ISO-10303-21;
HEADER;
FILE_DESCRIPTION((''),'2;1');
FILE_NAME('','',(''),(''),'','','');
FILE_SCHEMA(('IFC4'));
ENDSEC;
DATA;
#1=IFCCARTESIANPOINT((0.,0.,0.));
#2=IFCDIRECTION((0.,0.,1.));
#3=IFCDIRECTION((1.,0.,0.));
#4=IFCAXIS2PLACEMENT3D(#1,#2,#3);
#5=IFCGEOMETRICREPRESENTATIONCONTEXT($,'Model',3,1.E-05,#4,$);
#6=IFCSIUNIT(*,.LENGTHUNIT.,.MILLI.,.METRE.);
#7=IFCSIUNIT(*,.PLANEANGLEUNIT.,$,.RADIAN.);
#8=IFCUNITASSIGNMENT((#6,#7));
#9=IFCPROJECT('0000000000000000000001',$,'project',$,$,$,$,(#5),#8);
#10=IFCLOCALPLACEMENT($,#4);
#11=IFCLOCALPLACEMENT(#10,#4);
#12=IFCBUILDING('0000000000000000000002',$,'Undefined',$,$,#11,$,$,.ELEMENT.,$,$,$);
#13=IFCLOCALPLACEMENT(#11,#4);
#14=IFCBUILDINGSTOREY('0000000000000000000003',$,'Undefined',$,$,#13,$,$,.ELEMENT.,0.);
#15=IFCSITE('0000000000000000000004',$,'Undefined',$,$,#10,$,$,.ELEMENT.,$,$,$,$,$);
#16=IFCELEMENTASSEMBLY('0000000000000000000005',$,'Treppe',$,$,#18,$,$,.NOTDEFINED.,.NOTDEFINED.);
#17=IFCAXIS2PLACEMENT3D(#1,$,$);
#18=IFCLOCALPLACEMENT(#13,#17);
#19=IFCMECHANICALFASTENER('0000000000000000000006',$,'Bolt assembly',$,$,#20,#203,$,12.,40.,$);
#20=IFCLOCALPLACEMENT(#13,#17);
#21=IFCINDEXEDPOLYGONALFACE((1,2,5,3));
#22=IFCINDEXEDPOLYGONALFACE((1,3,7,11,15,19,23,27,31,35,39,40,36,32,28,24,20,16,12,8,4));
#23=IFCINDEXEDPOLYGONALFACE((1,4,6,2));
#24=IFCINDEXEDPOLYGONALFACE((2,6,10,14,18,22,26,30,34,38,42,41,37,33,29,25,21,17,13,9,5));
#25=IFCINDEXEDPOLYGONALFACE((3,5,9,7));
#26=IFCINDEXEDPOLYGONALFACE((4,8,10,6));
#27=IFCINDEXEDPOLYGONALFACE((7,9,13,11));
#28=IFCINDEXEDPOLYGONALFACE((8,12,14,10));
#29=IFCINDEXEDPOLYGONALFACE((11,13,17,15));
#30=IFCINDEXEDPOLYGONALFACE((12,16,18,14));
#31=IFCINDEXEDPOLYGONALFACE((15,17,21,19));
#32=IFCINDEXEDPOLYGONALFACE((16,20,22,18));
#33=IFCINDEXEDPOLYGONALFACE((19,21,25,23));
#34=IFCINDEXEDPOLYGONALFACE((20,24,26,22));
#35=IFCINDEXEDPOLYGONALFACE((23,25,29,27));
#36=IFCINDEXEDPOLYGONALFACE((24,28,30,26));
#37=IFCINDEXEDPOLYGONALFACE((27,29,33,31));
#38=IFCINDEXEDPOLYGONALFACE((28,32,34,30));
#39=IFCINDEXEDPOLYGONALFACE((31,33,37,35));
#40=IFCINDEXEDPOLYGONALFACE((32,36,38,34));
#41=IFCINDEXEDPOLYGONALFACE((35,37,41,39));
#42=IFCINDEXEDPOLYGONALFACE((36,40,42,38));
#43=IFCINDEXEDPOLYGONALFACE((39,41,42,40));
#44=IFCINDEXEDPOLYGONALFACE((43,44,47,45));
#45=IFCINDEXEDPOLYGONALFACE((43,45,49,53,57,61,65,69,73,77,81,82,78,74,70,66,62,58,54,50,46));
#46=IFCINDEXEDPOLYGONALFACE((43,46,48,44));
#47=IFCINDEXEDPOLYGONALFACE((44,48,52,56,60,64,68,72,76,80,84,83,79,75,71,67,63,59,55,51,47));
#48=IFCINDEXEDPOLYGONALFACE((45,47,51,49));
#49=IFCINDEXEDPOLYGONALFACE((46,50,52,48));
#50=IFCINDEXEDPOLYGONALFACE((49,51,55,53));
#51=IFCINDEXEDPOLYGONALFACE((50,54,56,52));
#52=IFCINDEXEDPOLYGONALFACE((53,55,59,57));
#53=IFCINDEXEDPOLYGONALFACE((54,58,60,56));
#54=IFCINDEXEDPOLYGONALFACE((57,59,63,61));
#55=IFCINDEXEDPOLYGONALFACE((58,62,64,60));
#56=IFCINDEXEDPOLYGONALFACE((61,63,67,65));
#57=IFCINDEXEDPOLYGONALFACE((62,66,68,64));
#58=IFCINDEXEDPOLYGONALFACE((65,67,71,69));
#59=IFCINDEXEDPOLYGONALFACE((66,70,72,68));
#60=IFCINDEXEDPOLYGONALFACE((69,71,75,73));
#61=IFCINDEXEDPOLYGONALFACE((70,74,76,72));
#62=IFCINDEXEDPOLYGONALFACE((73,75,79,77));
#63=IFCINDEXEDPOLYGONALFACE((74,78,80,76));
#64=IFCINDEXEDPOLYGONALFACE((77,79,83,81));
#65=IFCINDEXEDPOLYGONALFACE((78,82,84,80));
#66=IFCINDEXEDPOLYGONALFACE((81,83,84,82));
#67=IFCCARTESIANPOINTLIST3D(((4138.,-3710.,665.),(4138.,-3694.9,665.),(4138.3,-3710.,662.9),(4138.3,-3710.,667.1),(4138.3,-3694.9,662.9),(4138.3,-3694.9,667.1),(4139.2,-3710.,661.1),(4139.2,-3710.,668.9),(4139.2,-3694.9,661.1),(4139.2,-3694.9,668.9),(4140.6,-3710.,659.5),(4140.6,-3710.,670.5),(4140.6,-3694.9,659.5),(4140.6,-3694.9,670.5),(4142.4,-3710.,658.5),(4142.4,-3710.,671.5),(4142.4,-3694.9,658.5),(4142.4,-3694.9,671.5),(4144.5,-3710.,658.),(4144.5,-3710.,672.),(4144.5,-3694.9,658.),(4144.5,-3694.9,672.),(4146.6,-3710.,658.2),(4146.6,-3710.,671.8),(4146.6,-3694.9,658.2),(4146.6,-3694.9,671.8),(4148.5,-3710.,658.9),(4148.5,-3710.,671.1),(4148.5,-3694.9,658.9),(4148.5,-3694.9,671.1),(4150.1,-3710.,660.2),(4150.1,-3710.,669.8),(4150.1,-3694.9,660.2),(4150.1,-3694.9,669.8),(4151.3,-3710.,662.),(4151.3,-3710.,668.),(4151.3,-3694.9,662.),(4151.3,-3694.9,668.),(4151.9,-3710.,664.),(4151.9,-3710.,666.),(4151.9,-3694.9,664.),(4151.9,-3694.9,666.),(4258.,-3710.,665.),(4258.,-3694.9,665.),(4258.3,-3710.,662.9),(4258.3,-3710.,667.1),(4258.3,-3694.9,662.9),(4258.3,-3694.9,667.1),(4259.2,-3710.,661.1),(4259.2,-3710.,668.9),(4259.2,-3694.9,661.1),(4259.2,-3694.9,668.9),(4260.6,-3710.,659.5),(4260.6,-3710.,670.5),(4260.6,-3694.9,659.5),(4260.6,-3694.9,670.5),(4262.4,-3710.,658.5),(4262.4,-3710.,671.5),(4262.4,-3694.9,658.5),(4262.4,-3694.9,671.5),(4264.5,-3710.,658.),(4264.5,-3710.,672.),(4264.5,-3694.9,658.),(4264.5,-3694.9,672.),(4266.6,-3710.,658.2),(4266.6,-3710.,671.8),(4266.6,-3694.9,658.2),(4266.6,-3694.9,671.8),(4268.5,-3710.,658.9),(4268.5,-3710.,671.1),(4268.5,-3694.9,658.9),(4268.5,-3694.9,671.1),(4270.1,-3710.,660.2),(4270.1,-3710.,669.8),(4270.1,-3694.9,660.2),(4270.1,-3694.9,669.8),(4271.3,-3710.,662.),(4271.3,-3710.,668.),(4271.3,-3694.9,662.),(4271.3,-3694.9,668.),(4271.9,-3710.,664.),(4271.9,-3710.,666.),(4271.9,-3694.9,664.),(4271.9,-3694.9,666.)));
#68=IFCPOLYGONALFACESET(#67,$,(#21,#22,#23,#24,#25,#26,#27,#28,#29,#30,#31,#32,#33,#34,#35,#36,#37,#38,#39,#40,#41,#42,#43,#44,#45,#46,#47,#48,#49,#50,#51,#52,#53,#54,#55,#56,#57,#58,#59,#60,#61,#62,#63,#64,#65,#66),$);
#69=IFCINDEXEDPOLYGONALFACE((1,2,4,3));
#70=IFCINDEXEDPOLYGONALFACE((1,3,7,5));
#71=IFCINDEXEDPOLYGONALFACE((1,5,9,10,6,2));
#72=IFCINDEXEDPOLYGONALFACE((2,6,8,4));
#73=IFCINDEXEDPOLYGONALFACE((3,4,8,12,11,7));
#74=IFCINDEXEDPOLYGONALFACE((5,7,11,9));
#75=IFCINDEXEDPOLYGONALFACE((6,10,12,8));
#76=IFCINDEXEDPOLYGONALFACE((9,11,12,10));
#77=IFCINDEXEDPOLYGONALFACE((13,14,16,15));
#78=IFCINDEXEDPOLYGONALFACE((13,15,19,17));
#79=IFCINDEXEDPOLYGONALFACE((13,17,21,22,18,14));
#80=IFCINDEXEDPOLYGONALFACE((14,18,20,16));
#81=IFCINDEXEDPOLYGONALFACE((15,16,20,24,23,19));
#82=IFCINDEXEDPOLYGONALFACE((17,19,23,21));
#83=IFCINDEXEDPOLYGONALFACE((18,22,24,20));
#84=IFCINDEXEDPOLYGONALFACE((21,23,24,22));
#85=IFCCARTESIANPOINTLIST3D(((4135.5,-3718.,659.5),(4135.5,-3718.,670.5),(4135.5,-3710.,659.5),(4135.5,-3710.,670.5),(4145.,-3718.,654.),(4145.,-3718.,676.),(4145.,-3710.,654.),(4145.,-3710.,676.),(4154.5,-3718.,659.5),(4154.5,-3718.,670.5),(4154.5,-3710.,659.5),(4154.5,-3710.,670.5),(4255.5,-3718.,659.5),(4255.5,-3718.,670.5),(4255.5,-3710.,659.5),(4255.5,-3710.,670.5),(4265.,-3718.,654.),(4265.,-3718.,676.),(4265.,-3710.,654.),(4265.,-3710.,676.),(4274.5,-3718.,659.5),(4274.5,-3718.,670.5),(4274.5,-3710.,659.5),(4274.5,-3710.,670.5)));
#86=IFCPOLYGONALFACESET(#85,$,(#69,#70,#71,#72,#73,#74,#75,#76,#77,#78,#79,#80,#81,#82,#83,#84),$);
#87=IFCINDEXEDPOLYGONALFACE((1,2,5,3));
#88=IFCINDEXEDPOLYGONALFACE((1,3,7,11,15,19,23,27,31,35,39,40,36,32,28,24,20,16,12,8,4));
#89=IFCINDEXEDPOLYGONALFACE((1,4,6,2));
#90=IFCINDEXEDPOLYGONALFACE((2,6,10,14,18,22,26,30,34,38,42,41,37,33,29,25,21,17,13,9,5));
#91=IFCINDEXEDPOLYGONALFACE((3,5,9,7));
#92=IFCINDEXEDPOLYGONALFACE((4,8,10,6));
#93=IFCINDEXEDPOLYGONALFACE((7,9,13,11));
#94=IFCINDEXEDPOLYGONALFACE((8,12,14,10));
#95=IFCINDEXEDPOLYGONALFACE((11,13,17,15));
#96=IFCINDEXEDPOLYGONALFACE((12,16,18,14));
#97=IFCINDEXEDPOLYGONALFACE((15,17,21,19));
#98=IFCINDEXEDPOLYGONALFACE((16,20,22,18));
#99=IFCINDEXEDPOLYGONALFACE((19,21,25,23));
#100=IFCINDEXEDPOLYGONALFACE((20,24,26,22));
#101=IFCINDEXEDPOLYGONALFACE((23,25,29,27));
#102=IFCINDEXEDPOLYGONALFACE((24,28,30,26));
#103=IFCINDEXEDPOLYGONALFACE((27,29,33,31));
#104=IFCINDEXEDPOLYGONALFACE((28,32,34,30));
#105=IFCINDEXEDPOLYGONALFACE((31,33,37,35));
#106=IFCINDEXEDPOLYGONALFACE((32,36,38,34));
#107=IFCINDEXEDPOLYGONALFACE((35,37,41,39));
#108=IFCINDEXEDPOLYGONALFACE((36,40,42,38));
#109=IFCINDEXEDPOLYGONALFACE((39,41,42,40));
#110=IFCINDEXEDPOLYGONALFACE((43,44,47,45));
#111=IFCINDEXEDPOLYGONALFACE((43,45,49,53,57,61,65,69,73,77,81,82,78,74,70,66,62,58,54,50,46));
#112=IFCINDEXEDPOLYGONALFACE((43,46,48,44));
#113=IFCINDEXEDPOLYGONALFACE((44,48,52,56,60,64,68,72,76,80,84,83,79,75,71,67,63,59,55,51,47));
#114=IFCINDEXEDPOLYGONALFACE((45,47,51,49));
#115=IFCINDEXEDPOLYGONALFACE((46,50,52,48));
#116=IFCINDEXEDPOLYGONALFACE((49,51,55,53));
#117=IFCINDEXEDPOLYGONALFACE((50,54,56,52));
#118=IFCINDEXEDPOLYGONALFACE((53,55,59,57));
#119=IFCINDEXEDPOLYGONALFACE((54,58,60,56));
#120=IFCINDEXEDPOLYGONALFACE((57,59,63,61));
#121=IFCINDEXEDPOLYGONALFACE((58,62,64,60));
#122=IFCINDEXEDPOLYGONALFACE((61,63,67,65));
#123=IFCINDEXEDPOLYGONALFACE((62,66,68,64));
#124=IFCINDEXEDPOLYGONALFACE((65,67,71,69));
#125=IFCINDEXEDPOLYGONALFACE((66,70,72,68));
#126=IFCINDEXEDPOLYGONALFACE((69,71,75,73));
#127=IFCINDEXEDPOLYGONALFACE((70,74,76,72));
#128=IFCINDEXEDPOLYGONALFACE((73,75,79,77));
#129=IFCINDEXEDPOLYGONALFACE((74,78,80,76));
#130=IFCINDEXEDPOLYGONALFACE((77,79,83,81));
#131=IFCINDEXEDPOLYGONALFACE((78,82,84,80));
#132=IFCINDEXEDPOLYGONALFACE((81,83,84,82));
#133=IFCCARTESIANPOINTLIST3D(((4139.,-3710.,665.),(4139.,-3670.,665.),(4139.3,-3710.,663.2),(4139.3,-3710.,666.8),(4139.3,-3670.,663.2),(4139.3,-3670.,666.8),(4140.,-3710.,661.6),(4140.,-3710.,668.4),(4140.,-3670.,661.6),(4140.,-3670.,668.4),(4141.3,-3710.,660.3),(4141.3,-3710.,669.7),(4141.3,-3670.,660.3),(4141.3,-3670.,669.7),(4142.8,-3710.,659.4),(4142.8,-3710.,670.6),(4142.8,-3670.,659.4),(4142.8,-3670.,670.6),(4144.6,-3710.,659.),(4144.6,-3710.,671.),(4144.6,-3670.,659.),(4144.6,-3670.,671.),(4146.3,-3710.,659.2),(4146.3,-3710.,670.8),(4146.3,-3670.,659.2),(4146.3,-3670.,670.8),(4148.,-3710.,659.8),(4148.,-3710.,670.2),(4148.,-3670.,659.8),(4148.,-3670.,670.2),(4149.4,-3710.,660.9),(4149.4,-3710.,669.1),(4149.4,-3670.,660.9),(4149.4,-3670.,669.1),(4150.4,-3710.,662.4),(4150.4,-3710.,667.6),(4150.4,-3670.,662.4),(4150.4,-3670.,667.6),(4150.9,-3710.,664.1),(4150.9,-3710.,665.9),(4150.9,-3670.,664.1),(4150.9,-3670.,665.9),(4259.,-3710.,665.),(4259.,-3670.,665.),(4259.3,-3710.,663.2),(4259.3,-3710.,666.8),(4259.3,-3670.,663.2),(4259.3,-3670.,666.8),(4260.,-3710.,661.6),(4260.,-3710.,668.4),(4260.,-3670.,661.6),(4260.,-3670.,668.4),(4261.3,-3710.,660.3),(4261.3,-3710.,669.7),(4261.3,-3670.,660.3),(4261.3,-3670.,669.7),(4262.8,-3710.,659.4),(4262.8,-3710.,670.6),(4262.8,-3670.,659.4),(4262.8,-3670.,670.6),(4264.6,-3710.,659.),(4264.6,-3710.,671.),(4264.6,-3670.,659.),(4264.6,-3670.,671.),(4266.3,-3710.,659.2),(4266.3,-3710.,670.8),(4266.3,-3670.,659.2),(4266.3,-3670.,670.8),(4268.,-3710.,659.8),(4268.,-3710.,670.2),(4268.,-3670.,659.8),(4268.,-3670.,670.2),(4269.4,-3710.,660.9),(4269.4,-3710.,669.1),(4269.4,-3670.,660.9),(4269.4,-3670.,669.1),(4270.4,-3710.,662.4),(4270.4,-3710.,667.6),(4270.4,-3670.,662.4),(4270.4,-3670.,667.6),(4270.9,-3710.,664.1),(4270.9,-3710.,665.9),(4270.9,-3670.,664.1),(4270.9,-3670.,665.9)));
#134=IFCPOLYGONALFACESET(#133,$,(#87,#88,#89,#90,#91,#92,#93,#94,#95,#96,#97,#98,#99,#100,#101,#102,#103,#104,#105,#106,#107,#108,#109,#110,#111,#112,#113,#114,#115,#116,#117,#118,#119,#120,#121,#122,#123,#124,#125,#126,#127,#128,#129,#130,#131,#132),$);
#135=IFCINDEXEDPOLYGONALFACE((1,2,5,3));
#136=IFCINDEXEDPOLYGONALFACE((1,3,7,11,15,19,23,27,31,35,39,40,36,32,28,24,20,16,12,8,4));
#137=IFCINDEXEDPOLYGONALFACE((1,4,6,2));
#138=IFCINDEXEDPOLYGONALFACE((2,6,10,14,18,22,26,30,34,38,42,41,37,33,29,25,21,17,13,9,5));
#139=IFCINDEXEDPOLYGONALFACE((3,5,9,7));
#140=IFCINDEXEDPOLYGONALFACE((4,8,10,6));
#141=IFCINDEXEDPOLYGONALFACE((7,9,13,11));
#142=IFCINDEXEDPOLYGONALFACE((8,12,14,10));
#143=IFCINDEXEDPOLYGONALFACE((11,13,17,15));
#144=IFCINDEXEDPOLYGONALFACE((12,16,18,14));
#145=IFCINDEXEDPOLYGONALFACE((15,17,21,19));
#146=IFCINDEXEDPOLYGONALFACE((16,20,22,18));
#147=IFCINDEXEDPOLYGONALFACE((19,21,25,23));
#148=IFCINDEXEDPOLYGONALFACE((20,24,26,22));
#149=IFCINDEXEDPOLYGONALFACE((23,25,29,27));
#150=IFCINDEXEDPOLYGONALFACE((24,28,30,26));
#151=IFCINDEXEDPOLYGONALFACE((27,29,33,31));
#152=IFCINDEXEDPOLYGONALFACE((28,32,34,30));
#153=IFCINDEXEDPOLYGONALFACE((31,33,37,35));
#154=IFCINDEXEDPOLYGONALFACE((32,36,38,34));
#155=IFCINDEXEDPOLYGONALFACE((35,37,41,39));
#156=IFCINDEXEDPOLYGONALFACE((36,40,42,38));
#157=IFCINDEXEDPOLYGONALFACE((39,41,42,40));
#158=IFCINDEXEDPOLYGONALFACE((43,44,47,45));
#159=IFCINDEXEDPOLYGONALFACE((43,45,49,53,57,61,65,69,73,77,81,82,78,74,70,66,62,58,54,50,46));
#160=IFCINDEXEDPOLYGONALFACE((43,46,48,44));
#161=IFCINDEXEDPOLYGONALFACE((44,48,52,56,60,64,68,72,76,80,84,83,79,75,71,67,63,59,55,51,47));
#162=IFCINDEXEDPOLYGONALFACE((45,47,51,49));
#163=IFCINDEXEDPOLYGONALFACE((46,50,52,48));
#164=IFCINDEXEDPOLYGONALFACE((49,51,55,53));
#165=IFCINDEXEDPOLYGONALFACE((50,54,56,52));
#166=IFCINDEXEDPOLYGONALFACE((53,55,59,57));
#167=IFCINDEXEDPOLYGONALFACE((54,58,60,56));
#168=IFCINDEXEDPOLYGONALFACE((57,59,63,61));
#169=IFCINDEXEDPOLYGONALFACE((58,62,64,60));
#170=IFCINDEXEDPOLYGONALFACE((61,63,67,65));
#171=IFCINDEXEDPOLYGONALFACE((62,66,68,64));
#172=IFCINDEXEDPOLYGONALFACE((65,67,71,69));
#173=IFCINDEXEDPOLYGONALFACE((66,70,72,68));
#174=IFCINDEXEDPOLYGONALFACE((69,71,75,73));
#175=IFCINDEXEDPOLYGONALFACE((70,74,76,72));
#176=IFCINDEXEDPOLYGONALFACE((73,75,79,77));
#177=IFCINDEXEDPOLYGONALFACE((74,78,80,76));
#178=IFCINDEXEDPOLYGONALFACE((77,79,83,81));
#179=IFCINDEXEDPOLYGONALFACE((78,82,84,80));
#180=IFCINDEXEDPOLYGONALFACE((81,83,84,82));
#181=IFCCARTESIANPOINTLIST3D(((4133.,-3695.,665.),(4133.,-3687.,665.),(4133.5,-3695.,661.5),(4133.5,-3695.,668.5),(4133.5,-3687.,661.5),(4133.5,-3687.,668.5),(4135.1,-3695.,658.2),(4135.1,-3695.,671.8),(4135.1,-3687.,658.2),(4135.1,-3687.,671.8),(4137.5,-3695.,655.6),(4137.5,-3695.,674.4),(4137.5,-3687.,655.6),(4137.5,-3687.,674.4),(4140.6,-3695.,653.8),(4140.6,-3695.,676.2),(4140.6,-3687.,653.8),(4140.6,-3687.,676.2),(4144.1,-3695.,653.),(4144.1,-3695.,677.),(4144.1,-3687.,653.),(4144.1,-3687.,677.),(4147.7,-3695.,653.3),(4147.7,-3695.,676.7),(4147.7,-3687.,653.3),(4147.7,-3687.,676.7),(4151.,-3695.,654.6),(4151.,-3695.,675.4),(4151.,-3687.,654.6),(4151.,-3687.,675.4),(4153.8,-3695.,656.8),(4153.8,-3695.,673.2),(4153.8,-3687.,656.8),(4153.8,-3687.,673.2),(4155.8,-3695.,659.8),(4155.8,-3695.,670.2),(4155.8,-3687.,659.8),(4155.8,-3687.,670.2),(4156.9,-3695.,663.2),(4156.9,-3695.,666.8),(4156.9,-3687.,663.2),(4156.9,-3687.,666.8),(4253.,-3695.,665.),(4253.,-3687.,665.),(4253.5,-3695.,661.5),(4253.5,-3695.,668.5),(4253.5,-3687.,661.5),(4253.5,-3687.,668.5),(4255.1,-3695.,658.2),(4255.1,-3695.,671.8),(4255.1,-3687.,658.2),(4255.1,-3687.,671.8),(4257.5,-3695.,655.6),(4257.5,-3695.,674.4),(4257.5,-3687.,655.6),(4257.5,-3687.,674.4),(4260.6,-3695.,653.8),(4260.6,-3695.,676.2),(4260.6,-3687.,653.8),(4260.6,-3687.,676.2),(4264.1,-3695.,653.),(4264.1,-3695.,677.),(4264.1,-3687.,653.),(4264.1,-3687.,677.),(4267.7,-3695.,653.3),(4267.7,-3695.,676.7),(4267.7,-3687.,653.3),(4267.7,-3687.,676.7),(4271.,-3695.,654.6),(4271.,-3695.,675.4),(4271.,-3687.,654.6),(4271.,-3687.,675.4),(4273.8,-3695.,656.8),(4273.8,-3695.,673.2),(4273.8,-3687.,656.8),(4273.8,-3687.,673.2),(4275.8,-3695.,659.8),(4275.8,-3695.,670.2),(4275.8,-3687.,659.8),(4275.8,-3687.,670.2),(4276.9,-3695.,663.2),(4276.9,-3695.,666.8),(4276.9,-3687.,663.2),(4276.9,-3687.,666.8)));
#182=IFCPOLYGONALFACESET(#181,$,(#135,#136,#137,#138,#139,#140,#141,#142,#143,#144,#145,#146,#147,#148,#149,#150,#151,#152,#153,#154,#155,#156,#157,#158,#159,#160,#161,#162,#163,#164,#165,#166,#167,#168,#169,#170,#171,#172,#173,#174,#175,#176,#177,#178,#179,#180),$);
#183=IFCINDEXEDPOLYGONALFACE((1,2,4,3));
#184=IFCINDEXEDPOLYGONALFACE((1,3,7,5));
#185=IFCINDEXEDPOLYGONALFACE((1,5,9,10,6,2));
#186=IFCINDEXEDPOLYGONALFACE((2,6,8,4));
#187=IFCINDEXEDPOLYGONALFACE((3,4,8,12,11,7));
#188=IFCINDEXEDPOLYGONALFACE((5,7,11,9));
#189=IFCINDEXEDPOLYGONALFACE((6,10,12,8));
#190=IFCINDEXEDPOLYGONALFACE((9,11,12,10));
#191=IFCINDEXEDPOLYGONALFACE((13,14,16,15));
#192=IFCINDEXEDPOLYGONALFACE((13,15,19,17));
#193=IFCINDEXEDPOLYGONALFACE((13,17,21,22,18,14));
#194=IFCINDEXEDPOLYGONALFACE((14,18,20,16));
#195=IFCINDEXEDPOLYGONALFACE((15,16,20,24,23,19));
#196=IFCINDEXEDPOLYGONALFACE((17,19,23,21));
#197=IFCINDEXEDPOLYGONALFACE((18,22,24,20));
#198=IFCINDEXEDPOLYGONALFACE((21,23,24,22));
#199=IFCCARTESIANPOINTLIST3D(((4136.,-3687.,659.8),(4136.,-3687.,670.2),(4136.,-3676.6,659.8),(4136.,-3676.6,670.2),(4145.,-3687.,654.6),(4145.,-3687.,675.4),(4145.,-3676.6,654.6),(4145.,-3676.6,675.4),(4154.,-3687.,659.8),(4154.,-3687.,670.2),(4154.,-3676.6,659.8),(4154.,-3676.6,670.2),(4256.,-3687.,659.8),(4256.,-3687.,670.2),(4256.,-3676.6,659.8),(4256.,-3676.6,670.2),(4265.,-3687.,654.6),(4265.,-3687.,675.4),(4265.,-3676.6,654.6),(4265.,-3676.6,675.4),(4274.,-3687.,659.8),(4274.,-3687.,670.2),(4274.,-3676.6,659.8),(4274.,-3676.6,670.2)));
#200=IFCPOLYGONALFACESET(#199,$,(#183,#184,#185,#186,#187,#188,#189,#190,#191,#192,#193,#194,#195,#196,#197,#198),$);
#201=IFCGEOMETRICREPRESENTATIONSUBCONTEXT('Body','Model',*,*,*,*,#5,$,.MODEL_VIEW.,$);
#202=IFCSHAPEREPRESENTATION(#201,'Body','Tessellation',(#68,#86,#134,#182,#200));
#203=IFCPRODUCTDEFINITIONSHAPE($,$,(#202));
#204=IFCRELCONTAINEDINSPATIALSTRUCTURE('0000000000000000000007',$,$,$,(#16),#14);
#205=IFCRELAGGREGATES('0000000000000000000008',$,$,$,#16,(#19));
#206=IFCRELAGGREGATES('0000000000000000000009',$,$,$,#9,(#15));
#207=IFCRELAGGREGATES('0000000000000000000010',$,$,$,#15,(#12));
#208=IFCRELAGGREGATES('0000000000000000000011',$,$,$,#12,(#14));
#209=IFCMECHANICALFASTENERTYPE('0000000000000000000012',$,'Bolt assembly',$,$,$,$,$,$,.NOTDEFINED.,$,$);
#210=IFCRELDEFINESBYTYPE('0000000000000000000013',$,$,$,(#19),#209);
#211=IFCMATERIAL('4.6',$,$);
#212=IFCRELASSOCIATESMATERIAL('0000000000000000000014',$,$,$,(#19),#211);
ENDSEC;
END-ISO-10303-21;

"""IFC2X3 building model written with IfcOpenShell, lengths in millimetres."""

from ifc_helpers import new_model, si_unit, frame, origin_with_axes, origin_2d_with_axis, place, context, subcontext, project, spatial, polyline, circle, outline, extrude, source, transform, mapped, material, type_object, element, aggregate, save


model = new_model("IFC2X3")

# Units and contexts
model_context = context("Model", 3, precision=1e-05, world=origin_with_axes())
body_context = subcontext(model_context, "Body", "Model", "MODEL_VIEW")
ifc_project = project(units=[si_unit("LENGTHUNIT", "METRE", prefix="MILLI"), si_unit("PLANEANGLEUNIT", "RADIAN")], contexts=[model_context])

# Site, building, storey
site_placement = place(None, origin_with_axes())
site = spatial("IfcSite", under=ifc_project, at=site_placement, Name="Undefined", CompositionType="ELEMENT")
building_placement = place(site_placement, origin_with_axes())
building = spatial("IfcBuilding", under=site, at=building_placement, Name="Undefined", CompositionType="ELEMENT")
storey_placement = place(building_placement, origin_with_axes())
storey = spatial("IfcBuildingStorey", under=building, at=storey_placement, Name="Undefined", CompositionType="ELEMENT", Elevation=0.0)

# Element assembly, mechanical fastener
assembly_1_placement = place(storey_placement, origin_with_axes())
assembly_1 = element("IfcElementAssembly", 1, at=assembly_1_placement, inside=storey, Name="Treppe", AssemblyPlace="NOTDEFINED", PredefinedType="NOTDEFINED")
ifc_material_1 = material(Name="4.6")
mechanical_fastener_type = type_object("IfcMechanicalFastenerType", Name="Bolt assembly")
shared_shape_1 = source(origin_with_axes(), body_context, "Body", "SweptSolid", [
    extrude(circle(Radius=7.0, at=origin_2d_with_axis()), frame((0.0, 0.0, 0.0), z_axis=(0.0, 1.0, 0.0), x_axis=(1.0, 0.0, 0.0)), (0.0, 0.0, 1.0), 15.1),
    extrude(outline(polyline([(9.5, -5.5), (9.5, 5.5), (0.0, 11.0), (-9.5, 5.5), (-9.5, -5.5), (0.0, -11.0), (9.5, -5.5)])), frame((0.0, -8.0, 0.0), z_axis=(0.0, 1.0, 0.0), x_axis=(1.0, 0.0, 0.0)), (0.0, 0.0, 1.0), 8.0),
    extrude(circle(Radius=6.0, at=origin_2d_with_axis()), frame((0.0, 0.0, 0.0), z_axis=(0.0, 1.0, 0.0), x_axis=(1.0, 0.0, 0.0)), (0.0, 0.0, 1.0), 40.0),
    extrude(circle(Radius=12.0, at=origin_2d_with_axis()), frame((0.0, 15.0, 0.0), z_axis=(0.0, 1.0, 0.0), x_axis=(1.0, 0.0, 0.0)), (0.0, 0.0, 1.0), 8.0),
    extrude(outline(polyline([(9.0, -5.2), (9.0, 5.2), (0.0, 10.4), (-9.0, 5.2), (-9.0, -5.2), (0.0, -10.4), (9.0, -5.2)])), frame((0.0, 23.0, 0.0), z_axis=(0.0, 1.0, 0.0), x_axis=(1.0, 0.0, 0.0)), (0.0, 0.0, 1.0), 10.4),
])
mechanical_fastener_1_placement = place(assembly_1_placement, frame((4265.0, -3710.0, 665.0), z_axis=(0.0, 0.0, -1.0), x_axis=(-1.0, 0.0, 0.0)))
mechanical_fastener_1 = element("IfcMechanicalFastener", 2, at=mechanical_fastener_1_placement, type_object=mechanical_fastener_type, material=ifc_material_1, Name="Bolt assembly", NominalDiameter=12.0, NominalLength=40.0, context=body_context, shape_type="MappedRepresentation", body=[
    mapped(shared_shape_1, transform((0.0, 0.0, 0.0))),
    mapped(shared_shape_1, transform((120.0, 0.0, 0.0))),
])
aggregate(assembly_1, [mechanical_fastener_1])

save(model, "model.ifc")
